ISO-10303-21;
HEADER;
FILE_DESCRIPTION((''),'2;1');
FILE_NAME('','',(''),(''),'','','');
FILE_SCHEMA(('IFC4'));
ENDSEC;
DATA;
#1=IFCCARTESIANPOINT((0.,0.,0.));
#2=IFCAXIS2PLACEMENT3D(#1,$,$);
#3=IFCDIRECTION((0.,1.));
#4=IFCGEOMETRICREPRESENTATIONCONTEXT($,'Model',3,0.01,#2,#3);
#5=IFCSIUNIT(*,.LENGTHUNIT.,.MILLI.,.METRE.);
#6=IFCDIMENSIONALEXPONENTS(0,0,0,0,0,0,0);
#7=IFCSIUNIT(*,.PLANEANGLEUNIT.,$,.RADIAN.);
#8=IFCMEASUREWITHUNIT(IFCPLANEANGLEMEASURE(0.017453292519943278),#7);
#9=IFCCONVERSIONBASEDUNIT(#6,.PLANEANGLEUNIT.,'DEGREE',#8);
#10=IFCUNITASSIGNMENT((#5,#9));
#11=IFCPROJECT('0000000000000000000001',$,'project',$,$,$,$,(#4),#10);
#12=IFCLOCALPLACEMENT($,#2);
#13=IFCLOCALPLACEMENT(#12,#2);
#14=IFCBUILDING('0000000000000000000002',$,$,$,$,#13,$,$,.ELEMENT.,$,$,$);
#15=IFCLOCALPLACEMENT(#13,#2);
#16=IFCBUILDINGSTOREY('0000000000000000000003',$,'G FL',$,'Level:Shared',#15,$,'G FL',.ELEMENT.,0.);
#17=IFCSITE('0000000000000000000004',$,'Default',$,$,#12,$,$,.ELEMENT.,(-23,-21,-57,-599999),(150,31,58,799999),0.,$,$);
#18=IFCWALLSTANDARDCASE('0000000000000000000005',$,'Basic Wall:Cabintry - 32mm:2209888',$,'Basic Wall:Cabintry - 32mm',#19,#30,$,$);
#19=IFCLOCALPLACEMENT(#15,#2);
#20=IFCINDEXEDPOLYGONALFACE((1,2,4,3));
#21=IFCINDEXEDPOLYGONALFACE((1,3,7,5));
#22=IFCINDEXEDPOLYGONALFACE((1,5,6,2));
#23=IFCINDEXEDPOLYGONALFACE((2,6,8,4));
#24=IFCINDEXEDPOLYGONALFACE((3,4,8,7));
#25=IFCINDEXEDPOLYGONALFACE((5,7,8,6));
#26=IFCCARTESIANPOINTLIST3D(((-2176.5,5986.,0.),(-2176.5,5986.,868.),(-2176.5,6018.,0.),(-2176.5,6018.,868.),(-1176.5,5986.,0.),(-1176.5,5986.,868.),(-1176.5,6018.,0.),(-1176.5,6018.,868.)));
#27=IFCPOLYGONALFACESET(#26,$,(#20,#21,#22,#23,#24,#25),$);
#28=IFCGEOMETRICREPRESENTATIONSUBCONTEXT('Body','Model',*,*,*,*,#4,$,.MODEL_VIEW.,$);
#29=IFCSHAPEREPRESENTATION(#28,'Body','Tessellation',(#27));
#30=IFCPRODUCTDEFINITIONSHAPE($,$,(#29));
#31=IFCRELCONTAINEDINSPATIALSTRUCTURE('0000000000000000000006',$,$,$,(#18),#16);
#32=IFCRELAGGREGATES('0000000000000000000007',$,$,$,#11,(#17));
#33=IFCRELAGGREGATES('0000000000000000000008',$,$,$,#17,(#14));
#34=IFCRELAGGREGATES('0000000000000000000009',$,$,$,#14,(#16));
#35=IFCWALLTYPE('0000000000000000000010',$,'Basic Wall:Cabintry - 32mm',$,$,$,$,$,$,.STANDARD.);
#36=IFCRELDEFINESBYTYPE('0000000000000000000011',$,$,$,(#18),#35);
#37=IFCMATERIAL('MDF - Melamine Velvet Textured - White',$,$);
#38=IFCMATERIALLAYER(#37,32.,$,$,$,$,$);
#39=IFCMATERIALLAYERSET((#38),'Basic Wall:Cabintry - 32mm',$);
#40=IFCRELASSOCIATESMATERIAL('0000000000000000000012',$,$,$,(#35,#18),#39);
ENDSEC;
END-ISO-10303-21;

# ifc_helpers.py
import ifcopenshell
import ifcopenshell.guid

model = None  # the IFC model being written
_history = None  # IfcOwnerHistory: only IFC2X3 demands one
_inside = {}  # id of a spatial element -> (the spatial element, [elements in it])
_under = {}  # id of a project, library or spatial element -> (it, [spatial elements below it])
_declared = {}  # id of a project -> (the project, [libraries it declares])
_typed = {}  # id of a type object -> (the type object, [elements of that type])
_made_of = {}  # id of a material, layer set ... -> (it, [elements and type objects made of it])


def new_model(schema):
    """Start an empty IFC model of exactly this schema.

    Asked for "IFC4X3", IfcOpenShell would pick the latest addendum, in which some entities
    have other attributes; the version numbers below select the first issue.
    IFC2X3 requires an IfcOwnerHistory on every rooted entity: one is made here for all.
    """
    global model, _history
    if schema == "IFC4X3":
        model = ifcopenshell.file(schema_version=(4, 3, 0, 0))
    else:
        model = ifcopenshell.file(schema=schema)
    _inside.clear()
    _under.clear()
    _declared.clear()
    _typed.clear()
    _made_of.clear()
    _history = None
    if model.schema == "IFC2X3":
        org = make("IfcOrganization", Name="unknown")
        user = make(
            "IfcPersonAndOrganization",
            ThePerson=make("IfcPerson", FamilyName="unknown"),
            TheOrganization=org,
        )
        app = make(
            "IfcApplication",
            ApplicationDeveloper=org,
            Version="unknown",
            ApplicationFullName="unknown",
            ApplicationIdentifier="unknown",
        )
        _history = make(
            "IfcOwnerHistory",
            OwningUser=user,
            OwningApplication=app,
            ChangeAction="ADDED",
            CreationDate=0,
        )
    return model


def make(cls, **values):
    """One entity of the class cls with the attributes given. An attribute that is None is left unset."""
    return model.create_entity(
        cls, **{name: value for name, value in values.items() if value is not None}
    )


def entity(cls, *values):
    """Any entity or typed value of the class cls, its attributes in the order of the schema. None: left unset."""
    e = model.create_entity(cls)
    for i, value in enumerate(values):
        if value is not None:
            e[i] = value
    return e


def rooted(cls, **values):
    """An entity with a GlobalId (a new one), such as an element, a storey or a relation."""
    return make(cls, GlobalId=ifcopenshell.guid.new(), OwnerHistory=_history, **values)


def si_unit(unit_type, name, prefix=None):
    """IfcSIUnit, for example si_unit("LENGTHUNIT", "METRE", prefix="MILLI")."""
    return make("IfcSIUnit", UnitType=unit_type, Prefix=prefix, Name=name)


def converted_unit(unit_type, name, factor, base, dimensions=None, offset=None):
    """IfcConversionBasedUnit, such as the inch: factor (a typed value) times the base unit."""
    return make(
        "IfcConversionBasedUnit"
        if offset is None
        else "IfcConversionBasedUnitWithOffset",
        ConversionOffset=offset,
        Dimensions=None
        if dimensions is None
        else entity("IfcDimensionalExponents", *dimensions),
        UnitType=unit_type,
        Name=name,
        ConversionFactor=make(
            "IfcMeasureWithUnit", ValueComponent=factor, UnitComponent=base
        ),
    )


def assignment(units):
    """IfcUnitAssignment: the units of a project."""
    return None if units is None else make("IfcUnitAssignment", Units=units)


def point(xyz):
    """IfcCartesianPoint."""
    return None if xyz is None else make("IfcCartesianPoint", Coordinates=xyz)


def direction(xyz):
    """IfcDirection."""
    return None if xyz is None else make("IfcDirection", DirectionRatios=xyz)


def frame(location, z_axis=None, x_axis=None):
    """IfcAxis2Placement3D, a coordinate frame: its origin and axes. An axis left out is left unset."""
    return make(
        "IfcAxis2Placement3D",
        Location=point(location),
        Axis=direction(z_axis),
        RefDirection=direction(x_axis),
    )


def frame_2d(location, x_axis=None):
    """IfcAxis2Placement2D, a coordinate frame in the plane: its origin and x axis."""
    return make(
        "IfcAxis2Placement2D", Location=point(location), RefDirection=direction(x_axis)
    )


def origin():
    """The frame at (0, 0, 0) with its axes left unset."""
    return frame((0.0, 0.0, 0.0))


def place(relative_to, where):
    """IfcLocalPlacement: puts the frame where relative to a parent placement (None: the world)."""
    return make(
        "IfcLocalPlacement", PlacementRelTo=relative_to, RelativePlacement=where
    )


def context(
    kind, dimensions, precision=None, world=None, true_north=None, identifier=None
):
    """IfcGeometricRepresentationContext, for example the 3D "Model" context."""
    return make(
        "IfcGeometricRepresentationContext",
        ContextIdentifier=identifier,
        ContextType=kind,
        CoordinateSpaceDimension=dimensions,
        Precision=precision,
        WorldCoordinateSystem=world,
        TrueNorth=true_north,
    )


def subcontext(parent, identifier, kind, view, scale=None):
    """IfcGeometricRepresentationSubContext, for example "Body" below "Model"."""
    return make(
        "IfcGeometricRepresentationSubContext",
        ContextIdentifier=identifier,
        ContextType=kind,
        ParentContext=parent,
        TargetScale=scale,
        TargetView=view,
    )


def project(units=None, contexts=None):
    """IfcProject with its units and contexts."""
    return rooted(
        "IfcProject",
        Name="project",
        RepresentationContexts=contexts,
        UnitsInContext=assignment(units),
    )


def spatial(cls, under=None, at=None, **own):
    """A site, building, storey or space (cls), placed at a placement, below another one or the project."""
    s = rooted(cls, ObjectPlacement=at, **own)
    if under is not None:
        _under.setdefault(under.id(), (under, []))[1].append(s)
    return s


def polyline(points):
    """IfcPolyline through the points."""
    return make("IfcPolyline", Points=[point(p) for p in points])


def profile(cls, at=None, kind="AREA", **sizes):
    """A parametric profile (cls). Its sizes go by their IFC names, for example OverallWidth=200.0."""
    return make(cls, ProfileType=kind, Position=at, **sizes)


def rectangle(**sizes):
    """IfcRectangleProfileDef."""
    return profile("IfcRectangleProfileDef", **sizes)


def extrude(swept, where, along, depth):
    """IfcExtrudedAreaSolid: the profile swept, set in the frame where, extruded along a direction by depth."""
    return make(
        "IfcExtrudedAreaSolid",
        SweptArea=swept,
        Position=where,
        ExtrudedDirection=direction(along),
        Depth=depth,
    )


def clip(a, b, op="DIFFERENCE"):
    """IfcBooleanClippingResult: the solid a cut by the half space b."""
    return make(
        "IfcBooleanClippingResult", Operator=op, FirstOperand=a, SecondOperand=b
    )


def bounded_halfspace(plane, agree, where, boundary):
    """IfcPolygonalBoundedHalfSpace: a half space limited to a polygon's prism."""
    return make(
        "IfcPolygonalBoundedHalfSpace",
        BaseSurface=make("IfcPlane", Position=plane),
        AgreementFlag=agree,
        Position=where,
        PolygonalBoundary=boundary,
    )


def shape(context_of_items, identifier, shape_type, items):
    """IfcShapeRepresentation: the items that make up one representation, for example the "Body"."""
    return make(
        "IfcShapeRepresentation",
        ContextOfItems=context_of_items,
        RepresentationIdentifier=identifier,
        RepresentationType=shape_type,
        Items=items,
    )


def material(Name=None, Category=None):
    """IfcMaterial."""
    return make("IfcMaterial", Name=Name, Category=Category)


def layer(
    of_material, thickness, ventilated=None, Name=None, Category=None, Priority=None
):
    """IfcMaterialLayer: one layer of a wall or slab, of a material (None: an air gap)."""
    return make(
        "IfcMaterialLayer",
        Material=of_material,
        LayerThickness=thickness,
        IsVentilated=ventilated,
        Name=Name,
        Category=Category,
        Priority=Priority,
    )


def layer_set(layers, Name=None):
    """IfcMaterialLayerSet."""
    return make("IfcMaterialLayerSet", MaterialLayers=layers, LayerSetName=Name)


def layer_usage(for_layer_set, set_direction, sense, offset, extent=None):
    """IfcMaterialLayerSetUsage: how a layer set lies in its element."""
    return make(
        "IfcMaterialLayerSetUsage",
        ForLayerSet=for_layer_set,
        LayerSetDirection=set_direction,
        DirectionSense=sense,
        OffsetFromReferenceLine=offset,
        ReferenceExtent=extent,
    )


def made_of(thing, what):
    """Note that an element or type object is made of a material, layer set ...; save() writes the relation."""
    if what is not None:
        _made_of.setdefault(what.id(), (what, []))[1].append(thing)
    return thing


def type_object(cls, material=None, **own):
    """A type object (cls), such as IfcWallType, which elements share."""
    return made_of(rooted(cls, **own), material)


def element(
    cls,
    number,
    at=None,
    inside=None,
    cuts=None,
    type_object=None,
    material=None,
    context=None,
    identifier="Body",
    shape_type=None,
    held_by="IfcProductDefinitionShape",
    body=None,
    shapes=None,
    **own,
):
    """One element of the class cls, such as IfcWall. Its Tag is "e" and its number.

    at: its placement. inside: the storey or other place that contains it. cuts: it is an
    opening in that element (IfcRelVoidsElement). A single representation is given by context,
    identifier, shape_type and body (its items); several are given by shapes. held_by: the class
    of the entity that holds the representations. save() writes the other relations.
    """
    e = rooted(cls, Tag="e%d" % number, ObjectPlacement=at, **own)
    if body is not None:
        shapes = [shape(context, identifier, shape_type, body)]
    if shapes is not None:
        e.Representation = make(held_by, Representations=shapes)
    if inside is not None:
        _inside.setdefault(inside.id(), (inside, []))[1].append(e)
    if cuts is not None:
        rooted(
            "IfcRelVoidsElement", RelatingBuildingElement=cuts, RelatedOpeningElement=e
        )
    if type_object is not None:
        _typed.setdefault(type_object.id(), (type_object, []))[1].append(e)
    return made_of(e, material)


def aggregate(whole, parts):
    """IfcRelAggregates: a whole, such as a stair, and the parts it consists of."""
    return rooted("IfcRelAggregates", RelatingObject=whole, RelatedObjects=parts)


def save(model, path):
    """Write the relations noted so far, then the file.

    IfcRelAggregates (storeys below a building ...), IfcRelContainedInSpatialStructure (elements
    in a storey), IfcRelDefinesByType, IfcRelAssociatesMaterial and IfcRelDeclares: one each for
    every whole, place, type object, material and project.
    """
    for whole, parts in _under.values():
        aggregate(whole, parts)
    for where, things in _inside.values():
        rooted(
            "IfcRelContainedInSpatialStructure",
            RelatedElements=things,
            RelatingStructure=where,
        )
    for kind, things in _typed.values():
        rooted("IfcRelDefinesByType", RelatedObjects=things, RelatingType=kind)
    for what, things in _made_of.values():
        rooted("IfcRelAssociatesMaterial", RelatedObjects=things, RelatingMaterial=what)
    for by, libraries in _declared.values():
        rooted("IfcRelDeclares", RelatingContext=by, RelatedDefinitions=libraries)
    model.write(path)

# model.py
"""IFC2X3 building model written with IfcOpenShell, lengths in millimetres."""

from ifc_helpers import new_model, entity, si_unit, converted_unit, direction, frame, frame_2d, origin, place, context, subcontext, project, spatial, polyline, rectangle, extrude, clip, bounded_halfspace, material, layer, layer_set, layer_usage, type_object, element, save


model = new_model("IFC2X3")

# Units and contexts
model_context = context("Model", 3, precision=0.01, world=origin(), true_north=direction((0.0, 1.0)))
body_context = subcontext(model_context, "Body", "Model", "MODEL_VIEW")
ifc_project = project(units=[si_unit("LENGTHUNIT", "METRE", prefix="MILLI"), converted_unit("PLANEANGLEUNIT", "DEGREE", entity("IfcPlaneAngleMeasure", 0.017453292519943278), si_unit("PLANEANGLEUNIT", "RADIAN"), dimensions=[0, 0, 0, 0, 0, 0, 0])], contexts=[model_context])

# Site, building, storey
site_placement = place(None, origin())
site = spatial("IfcSite", under=ifc_project, at=site_placement, Name="Default", CompositionType="ELEMENT", RefLatitude=(-23, -21, -57, -599999), RefLongitude=(150, 31, 58, 799999), RefElevation=0.0)
building_placement = place(site_placement, origin())
building = spatial("IfcBuilding", under=site, at=building_placement, CompositionType="ELEMENT")
storey_placement = place(building_placement, origin())
storey = spatial("IfcBuildingStorey", under=building, at=storey_placement, Name="G FL", ObjectType="Level:Shared", LongName="G FL", CompositionType="ELEMENT", Elevation=0.0)

# Shared definitions
ifc_material = material(Name="MDF - Melamine Velvet Textured - White")

# Wall
ifc_layer_1 = layer(ifc_material, 32.0)
ifc_layer_set_1 = layer_set([ifc_layer_1], Name="Basic Wall:Cabintry - 32mm")
ifc_layer_usage_1 = layer_usage(ifc_layer_set_1, "AXIS2", "POSITIVE", -16.0)
wall_type = type_object("IfcWallType", Name="Basic Wall:Cabintry - 32mm", PredefinedType="STANDARD", material=ifc_layer_set_1)
wall_placement = place(storey_placement, frame((-2176.5, 6002.0, 0.0)))
element("IfcWallStandardCase", 1, at=wall_placement, inside=storey, type_object=wall_type, material=ifc_layer_usage_1, Name="Basic Wall:Cabintry - 32mm:2209888", ObjectType="Basic Wall:Cabintry - 32mm", context=body_context, shape_type="Clipping", body=[
    clip(extrude(rectangle(XDim=1000.0, YDim=32.0, at=frame_2d((500.0, 0.0), x_axis=(-1.0, 0.0))), origin(), (0.0, 0.0, 1.0), 868.0), bounded_halfspace(frame((0.0, -16.0, 868.0), z_axis=(0.0, 0.0, -1.0), x_axis=(0.0, -1.0, 0.0)), True, frame((0.0, -16.0, 868.0)), polyline([(0.0, 0.0), (1000.0, 0.0), (1000.0, 32.0), (632.0, 32.0), (600.0, 32.0), (0.0, 32.0), (0.0, 0.0)]))),
])

save(model, "model.ifc")
